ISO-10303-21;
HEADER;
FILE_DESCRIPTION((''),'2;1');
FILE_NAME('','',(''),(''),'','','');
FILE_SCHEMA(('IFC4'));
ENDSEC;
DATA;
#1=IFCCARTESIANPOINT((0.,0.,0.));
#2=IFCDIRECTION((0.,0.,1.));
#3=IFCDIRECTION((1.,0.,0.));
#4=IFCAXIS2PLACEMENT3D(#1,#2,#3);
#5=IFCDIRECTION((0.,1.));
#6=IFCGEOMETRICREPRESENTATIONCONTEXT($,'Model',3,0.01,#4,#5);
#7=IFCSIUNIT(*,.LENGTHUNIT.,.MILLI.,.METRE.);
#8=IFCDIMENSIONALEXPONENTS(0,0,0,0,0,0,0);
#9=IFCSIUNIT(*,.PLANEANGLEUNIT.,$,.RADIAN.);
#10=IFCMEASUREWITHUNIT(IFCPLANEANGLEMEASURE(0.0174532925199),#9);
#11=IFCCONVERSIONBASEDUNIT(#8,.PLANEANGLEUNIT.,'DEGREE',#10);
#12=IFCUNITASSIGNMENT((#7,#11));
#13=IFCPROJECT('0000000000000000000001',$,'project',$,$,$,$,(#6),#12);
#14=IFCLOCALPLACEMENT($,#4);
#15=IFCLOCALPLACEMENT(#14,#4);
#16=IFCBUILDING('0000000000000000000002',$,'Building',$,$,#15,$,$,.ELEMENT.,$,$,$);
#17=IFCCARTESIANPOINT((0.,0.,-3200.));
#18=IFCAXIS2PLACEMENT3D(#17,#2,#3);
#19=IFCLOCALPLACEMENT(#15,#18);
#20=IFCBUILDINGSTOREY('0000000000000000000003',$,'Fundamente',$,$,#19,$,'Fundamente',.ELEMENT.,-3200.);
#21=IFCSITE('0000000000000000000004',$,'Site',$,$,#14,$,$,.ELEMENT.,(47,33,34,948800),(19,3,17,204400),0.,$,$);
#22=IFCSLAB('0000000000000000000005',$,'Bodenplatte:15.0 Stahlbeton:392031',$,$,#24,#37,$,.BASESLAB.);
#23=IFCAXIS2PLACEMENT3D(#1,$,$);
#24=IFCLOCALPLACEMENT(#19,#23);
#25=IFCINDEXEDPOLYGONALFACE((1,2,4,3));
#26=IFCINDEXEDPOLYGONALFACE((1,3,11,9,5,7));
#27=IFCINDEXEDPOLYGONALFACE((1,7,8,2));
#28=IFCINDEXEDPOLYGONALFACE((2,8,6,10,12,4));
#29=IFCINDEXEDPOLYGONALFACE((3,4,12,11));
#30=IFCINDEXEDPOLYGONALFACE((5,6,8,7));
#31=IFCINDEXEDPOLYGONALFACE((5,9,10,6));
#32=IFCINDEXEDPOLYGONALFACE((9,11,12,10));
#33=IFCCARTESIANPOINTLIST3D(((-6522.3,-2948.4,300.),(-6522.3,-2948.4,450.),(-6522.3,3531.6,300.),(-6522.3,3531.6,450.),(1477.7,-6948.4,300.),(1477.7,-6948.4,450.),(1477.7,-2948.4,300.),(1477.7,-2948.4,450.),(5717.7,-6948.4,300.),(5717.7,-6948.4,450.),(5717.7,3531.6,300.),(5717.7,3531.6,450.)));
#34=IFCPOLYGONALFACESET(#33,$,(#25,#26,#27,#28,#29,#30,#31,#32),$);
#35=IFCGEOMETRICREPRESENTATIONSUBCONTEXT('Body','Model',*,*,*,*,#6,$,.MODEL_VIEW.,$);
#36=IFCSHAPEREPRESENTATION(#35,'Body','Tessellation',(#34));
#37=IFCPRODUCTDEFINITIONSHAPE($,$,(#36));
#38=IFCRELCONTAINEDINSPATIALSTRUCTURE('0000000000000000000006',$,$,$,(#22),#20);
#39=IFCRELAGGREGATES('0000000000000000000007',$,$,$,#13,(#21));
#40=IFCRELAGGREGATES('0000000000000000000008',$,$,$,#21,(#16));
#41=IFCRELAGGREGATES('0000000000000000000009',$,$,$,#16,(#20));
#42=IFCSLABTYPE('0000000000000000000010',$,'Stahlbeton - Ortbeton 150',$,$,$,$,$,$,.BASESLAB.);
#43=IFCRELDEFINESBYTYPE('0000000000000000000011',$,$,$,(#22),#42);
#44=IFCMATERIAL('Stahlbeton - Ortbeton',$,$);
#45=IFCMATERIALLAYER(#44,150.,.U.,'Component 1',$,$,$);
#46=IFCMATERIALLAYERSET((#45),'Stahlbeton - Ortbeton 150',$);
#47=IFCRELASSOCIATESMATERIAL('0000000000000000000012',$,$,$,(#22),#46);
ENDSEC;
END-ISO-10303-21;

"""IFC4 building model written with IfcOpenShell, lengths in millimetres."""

from ifc_helpers import new_model, entity, si_unit, converted_unit, direction, frame, origin_with_axes, place, context, subcontext, project, spatial, line, indexed_curve, outline, extrude, material, layer, layer_set, layer_usage, type_object, element, save


model = new_model("IFC4")

# Units and contexts
model_context = context("Model", 3, precision=0.01, world=origin_with_axes(), true_north=direction((0.0, 1.0)))
body_context = subcontext(model_context, "Body", "Model", "MODEL_VIEW")
ifc_project = project(units=[si_unit("LENGTHUNIT", "METRE", prefix="MILLI"), converted_unit("PLANEANGLEUNIT", "DEGREE", entity("IfcPlaneAngleMeasure", 0.0174532925199), si_unit("PLANEANGLEUNIT", "RADIAN"), dimensions=[0, 0, 0, 0, 0, 0, 0])], contexts=[model_context])

# Site, building, storey
site_placement = place(None, origin_with_axes())
site = spatial("IfcSite", under=ifc_project, at=site_placement, Name="Site", CompositionType="ELEMENT", RefLatitude=(47, 33, 34, 948800), RefLongitude=(19, 3, 17, 204400), RefElevation=0.0)
building_placement = place(site_placement, origin_with_axes())
building = spatial("IfcBuilding", under=site, at=building_placement, Name="Building", CompositionType="ELEMENT")
storey_placement = place(building_placement, frame((0.0, 0.0, -3200.0), z_axis=(0.0, 0.0, 1.0), x_axis=(1.0, 0.0, 0.0)))
storey = spatial("IfcBuildingStorey", under=building, at=storey_placement, Name="Fundamente", LongName="Fundamente", CompositionType="ELEMENT", Elevation=-3200.0)

# Shared definitions
ifc_material = material(Name="Stahlbeton - Ortbeton")

# Slab
ifc_layer = layer(ifc_material, 150.0, ventilated="UNKNOWN", Name="Component 1")
ifc_layer_set = layer_set([ifc_layer], Name="Stahlbeton - Ortbeton 150")
ifc_layer_usage = layer_usage(ifc_layer_set, "AXIS3", "NEGATIVE", 150.0)
slab_type = type_object("IfcSlabType", Name="Stahlbeton - Ortbeton 150", PredefinedType="BASESLAB")
slab_placement = place(storey_placement, frame((-6522.3, -2948.4, 450.0), z_axis=(0.0, 0.0, 1.0), x_axis=(1.0, 0.0, 0.0)))
element("IfcSlab", 1, at=slab_placement, inside=storey, type_object=slab_type, material=ifc_layer_usage, Name="Bodenplatte:15.0 Stahlbeton:392031", PredefinedType="BASESLAB", context=body_context, shape_type="SweptSolid", body=[
    extrude(outline(indexed_curve([(0.0, 0.0), (8000.0, 0.0), (8000.0, -4000.0), (12240.0, -4000.0), (12240.0, 6480.0), (0.0, 6480.0)], segments=[line(1, 2, 3, 4, 5, 6, 1)])), frame((0.0, 0.0, -150.0), z_axis=(0.0, 0.0, 1.0), x_axis=(1.0, 0.0, 0.0)), (0.0, 0.0, 1.0), 150.0),
])

save(model, "model.ifc")
